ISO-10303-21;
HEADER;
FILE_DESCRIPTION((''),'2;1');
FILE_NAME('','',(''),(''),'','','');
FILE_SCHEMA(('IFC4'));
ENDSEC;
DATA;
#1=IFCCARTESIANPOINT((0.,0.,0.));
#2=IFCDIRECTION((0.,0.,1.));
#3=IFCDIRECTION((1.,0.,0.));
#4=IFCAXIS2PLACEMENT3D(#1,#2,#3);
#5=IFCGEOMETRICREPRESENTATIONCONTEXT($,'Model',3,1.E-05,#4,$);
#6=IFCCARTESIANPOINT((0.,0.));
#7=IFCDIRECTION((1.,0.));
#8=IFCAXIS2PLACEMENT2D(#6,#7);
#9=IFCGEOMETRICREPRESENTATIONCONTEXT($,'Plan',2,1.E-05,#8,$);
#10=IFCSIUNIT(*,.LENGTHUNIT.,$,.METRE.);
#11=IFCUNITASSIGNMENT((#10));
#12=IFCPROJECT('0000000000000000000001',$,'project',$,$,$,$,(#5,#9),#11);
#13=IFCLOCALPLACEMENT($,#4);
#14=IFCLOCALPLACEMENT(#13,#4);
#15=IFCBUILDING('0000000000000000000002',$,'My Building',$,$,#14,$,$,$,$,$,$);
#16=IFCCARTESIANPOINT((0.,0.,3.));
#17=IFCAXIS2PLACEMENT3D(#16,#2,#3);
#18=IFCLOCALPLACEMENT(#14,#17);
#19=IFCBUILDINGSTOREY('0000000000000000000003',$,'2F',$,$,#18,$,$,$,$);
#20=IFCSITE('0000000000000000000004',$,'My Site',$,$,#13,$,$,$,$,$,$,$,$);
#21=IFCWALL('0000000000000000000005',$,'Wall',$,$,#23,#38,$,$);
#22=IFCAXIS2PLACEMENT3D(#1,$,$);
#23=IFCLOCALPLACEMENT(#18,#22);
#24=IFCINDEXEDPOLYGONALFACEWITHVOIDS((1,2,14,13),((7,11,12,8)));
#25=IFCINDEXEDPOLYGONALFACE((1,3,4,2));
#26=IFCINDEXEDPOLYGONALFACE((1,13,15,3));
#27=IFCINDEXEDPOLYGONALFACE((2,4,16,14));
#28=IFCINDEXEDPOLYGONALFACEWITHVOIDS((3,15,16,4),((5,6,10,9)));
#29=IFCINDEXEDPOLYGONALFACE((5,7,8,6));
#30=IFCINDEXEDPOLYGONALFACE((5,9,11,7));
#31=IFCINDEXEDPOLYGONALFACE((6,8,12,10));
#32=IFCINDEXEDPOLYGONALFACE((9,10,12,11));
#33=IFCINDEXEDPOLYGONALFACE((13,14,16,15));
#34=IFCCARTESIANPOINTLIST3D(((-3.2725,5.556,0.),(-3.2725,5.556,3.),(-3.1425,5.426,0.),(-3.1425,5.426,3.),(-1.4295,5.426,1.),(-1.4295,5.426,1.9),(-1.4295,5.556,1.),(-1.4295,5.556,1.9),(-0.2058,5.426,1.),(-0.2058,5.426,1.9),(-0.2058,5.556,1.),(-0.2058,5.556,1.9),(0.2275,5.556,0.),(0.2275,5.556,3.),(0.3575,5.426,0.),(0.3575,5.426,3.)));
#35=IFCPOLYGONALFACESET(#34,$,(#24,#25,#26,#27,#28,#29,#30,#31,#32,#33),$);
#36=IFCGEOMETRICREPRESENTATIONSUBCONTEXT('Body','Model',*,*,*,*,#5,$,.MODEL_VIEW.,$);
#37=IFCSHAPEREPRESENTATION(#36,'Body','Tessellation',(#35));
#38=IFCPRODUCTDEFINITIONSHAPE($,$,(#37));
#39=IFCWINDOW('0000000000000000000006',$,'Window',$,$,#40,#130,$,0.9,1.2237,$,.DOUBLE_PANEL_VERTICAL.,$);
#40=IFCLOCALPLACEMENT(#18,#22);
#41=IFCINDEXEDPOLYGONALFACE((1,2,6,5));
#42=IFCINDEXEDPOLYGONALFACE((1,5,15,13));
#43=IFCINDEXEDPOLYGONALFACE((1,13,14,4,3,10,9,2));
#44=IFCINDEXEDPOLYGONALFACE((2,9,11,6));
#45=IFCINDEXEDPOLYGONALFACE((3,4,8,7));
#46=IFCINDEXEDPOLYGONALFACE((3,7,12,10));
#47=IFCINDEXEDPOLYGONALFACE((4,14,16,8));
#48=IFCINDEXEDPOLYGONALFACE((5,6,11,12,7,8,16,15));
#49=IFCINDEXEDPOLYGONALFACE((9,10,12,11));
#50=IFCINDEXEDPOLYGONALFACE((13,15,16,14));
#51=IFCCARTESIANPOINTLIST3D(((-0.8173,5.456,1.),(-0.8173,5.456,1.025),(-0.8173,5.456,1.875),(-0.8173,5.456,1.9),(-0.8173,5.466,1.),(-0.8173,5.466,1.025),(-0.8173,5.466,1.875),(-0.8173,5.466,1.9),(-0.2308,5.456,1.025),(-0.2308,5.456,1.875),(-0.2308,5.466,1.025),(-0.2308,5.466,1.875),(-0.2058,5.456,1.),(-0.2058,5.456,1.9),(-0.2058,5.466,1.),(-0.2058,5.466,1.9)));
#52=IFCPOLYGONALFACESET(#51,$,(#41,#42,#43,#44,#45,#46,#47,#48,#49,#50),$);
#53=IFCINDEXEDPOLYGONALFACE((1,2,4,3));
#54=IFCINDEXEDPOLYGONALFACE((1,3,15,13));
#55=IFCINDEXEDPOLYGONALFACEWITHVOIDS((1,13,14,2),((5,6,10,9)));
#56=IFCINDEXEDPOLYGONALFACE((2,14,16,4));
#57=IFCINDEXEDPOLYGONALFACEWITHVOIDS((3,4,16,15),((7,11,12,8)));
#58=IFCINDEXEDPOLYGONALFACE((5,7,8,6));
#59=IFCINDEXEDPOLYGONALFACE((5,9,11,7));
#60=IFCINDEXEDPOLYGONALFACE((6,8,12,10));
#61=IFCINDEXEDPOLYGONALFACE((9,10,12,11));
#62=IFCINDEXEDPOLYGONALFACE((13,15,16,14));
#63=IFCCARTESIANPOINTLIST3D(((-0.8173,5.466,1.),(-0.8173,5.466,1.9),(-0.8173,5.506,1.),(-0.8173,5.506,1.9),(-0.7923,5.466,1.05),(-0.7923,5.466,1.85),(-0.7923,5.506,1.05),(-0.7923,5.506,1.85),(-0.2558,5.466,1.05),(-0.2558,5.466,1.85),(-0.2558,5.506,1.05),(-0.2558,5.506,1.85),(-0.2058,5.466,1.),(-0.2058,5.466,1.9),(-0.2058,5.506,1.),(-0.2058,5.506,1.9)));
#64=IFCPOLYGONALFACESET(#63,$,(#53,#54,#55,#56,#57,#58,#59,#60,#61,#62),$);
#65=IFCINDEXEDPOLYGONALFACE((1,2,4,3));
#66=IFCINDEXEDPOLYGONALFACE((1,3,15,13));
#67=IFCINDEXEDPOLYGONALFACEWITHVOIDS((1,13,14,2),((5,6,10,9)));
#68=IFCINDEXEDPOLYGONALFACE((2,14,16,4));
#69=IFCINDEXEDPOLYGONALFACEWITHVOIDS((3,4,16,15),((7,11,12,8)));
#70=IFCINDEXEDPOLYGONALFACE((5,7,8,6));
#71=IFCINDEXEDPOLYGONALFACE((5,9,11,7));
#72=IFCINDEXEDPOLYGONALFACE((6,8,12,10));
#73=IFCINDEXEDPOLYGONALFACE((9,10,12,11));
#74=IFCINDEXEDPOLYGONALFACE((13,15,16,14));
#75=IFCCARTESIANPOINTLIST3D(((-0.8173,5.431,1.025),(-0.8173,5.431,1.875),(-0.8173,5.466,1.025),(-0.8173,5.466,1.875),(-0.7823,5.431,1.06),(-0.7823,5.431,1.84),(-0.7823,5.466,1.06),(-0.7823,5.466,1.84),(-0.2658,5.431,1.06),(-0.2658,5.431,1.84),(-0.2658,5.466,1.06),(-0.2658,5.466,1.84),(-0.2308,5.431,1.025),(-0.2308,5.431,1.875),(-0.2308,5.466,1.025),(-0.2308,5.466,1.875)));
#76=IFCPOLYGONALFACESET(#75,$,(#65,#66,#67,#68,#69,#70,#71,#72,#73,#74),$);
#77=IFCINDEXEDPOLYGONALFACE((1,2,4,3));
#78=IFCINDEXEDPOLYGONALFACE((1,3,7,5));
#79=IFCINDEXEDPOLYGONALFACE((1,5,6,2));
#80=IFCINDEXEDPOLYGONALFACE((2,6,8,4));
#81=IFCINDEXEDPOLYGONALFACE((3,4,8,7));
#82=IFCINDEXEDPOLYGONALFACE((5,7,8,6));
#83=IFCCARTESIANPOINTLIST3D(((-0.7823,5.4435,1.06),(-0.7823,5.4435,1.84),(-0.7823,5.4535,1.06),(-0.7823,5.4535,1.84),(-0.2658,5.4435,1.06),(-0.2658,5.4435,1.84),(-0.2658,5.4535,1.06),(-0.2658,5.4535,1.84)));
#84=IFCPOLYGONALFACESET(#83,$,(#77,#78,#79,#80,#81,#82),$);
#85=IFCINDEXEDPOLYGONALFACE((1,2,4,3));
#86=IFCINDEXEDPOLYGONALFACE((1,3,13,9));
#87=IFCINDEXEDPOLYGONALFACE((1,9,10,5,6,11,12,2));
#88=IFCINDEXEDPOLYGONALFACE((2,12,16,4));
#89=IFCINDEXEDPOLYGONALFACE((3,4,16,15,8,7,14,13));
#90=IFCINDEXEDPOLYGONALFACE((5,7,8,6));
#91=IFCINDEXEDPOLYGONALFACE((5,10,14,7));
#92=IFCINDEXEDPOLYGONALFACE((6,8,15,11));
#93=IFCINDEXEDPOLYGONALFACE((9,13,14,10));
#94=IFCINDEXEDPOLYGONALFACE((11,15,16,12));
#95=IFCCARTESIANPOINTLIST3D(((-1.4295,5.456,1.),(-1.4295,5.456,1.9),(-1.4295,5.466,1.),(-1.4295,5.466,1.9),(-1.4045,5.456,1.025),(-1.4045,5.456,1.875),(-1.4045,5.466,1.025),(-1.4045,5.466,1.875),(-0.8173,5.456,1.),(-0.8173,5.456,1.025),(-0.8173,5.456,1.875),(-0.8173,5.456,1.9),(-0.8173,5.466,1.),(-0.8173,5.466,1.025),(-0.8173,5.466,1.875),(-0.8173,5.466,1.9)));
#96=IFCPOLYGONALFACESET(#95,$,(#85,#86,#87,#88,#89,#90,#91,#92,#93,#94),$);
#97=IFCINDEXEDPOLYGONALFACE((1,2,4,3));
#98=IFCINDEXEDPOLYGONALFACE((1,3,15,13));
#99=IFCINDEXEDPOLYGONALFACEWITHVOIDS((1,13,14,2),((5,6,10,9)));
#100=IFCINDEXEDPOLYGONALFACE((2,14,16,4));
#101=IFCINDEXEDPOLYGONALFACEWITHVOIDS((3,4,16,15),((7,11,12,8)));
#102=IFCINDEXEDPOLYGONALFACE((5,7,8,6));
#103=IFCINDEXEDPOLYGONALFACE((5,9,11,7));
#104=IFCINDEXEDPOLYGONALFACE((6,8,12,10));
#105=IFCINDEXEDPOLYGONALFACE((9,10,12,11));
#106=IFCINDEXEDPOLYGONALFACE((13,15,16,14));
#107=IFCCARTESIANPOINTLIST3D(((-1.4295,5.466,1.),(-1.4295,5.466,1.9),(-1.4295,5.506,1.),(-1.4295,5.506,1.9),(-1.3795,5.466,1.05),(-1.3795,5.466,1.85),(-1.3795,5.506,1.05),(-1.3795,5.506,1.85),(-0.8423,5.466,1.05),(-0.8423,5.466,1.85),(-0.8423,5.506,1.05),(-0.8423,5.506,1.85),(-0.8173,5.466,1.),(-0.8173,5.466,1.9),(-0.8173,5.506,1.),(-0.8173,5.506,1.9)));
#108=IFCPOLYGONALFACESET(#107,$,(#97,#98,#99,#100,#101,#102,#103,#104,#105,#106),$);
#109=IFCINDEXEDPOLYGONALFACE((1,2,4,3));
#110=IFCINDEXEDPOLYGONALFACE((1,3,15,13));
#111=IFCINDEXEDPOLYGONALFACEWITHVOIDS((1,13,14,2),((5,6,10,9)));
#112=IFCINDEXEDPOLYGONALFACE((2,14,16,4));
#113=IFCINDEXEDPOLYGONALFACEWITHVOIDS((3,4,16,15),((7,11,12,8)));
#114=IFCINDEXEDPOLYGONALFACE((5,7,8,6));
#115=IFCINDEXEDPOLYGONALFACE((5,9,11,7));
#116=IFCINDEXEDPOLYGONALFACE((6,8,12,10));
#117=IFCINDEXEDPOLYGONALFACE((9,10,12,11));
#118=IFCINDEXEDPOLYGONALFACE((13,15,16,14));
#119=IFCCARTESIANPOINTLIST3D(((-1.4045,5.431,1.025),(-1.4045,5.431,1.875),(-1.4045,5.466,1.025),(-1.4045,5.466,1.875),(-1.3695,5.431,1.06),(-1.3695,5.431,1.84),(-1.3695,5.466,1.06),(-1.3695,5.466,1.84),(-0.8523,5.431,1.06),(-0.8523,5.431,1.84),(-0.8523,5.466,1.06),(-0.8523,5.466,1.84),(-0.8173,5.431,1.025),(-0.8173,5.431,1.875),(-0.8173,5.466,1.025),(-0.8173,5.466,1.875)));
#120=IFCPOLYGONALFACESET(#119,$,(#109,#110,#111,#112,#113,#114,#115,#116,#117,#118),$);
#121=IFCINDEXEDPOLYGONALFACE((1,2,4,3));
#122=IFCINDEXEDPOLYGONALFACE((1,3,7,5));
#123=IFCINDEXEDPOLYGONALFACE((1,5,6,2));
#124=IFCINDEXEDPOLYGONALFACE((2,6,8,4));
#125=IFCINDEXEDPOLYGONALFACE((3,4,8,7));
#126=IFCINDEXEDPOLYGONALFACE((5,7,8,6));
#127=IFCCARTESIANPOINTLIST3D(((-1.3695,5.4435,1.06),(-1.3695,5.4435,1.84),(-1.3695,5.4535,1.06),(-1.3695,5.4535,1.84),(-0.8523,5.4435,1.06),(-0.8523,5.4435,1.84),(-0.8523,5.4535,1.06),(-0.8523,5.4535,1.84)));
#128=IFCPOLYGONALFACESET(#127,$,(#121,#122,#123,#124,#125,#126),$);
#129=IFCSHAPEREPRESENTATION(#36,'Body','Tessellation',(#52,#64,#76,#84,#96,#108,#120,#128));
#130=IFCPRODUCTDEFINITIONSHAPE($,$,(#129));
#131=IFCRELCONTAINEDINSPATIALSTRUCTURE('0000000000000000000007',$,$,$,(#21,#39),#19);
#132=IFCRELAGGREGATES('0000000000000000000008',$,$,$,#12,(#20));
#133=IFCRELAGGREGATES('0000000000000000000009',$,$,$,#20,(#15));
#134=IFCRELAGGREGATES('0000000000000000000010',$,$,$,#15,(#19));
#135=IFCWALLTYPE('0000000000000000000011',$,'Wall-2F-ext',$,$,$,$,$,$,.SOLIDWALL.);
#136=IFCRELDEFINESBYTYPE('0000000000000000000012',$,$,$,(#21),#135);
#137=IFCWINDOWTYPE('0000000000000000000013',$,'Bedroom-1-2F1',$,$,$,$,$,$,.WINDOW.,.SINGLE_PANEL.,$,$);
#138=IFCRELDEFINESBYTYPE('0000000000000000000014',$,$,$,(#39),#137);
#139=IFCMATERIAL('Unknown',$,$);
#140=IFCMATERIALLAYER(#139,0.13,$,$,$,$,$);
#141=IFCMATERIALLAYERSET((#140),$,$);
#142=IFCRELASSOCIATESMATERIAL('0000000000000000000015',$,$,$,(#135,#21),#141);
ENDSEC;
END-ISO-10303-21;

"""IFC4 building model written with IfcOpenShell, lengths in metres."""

from ifc_helpers import new_model, entity, si_unit, frame, origin_with_axes, origin_2d_with_axis, place, context, subcontext, project, spatial, line, indexed_curve, outline, extrude, shape, source, transform, mapped, material, layer, layer_set, layer_usage, type_object, type_shapes, element, fill, save


model = new_model("IFC4")

# Units and contexts
model_context = context("Model", 3, precision=1e-05, world=origin_with_axes())
plan_context = context("Plan", 2, precision=1e-05, world=origin_2d_with_axis())
body_context_1 = subcontext(model_context, "Body", "Model", "MODEL_VIEW")
body_context_2 = subcontext(plan_context, "Body", "Plan", "PLAN_VIEW")
ifc_project = project(units=[si_unit("LENGTHUNIT", "METRE")], contexts=[model_context, plan_context])

# Site, building, storey
site_placement = place(None, origin_with_axes())
site = spatial("IfcSite", under=ifc_project, at=site_placement, Name="My Site")
building_placement = place(site_placement, origin_with_axes())
building = spatial("IfcBuilding", under=site, at=building_placement, Name="My Building")
storey_placement = place(building_placement, frame((0.0, 0.0, 3.0), z_axis=(0.0, 0.0, 1.0), x_axis=(1.0, 0.0, 0.0)))
storey = spatial("IfcBuildingStorey", under=building, at=storey_placement, Name="2F")

# Shared definitions
ifc_material = material(Name="Unknown")

# Shared definitions
ifc_layer_1 = layer(ifc_material, 0.13)
ifc_layer_set_1 = layer_set([ifc_layer_1])
wall_type_1 = type_object("IfcWallType", Name="Wall-2F-ext", PredefinedType="SOLIDWALL", material=ifc_layer_set_1)

# Wall, opening, window
ifc_layer_usage_1 = layer_usage(ifc_layer_set_1, "AXIS2", "POSITIVE", 0.0)
wall_1_placement = place(storey_placement, frame((0.2275, 5.556, 0.0), z_axis=(0.0, 0.0, 1.0), x_axis=(-1.0, 0.0, 0.0)))
wall_1 = element("IfcWall", 1, at=wall_1_placement, inside=storey, type_object=wall_type_1, material=ifc_layer_usage_1, Name="Wall", context=body_context_1, shape_type="SweptSolid", body=[
    extrude(outline(indexed_curve([(0.0, 0.0), (-0.13, 0.13), (3.37, 0.13), (3.5, 0.0)], segments=[line(1, 2, 3, 4, 1)])), origin_with_axes(), (0.0, 0.0, 1.0), 3.0),
])
shared_shape_1 = source(origin_with_axes(), body_context_1, "Body", "SweptSolid", [
    extrude(outline(indexed_curve([(0.0, 0.0), (1.2237, 0.0), (1.2237, 0.9), (0.0, 0.9)], segments=[line(1, 2, 3, 4, 1)])), frame((0.0, -0.6, 0.0), z_axis=(0.0, -1.0, 0.0), x_axis=(1.0, 0.0, 0.0)), (0.0, 0.0, -1.0), 1.2),
])
opening_1_placement = place(wall_1_placement, frame((0.4333, 0.0, 1.0), z_axis=(0.0, 0.0, 1.0), x_axis=(1.0, 0.0, 0.0)))
opening_1 = element("IfcOpeningElement", 2, at=opening_1_placement, cuts=wall_1, PredefinedType="OPENING", context=body_context_1, shape_type="MappedRepresentation", body=[
    mapped(shared_shape_1, transform((0.0, 0.0, 0.0), x_axis=(1.0, 0.0, 0.0), y_axis=(0.0, 1.0, 0.0), z_axis=(0.0, 0.0, 1.0), scale=1.0)),
])
window_type_1 = type_object("IfcWindowType", Name="Bedroom-1-2F1", PartitioningType="SINGLE_PANEL", PredefinedType="WINDOW")
shared_shape_2 = source(origin_with_axes(), body_context_1, "Body", "SweptSolid", [
    extrude(outline(indexed_curve([(0.6115, 0.0), (0.0, 0.0), (0.0, 0.9), (0.6115, 0.9), (0.6115, 0.875), (0.025, 0.875), (0.025, 0.025), (0.6115, 0.025)], segments=[line(1, 2, 3, 4, 5, 6, 7, 8, 1)])), frame((0.0, 0.09, 0.0), z_axis=(0.0, -1.0, 0.0), x_axis=(1.0, 0.0, 0.0)), (0.0, 0.0, -1.0), 0.01),
    extrude(outline(indexed_curve([(0.0, 0.0), (0.6115, 0.0), (0.6115, 0.9), (0.0, 0.9)], segments=[line(1, 2, 3, 4, 1)]), holes=[indexed_curve([(0.05, 0.05), (0.5865, 0.05), (0.5865, 0.85), (0.05, 0.85)], segments=[line(1, 2, 3, 4, 1)])]), frame((0.0, 0.05, 0.0), z_axis=(0.0, -1.0, 0.0), x_axis=(1.0, 0.0, 0.0)), (0.0, 0.0, -1.0), 0.04),
    extrude(outline(indexed_curve([(0.0, 0.0), (0.5865, 0.0), (0.5865, 0.85), (0.0, 0.85)], segments=[line(1, 2, 3, 4, 1)]), holes=[indexed_curve([(0.035, 0.035), (0.5515, 0.035), (0.5515, 0.815), (0.035, 0.815)], segments=[line(1, 2, 3, 4, 1)])]), frame((0.025, 0.09, 0.025), z_axis=(0.0, -1.0, 0.0), x_axis=(1.0, 0.0, 0.0)), (0.0, 0.0, -1.0), 0.035),
    extrude(outline(indexed_curve([(0.035, 0.035), (0.5515, 0.035), (0.5515, 0.815), (0.035, 0.815)], segments=[line(1, 2, 3, 4, 1)])), frame((0.025, 0.1025, 0.025), z_axis=(0.0, -1.0, 0.0), x_axis=(1.0, 0.0, 0.0)), (0.0, 0.0, -1.0), 0.01),
    extrude(outline(indexed_curve([(0.0, 0.9), (0.6122, 0.9), (0.6122, 0.0), (0.0, 0.0), (0.0, 0.025), (0.5872, 0.025), (0.5872, 0.875), (0.0, 0.875)], segments=[line(1, 2, 3, 4, 5, 6, 7, 8, 1)])), frame((0.6115, 0.09, 0.0), z_axis=(0.0, -1.0, 0.0), x_axis=(1.0, 0.0, 0.0)), (0.0, 0.0, -1.0), 0.01),
    extrude(outline(indexed_curve([(0.0, 0.0), (0.6122, 0.0), (0.6122, 0.9), (0.0, 0.9)], segments=[line(1, 2, 3, 4, 1)]), holes=[indexed_curve([(0.025, 0.05), (0.5622, 0.05), (0.5622, 0.85), (0.025, 0.85)], segments=[line(1, 2, 3, 4, 1)])]), frame((0.6115, 0.05, 0.0), z_axis=(0.0, -1.0, 0.0), x_axis=(1.0, 0.0, 0.0)), (0.0, 0.0, -1.0), 0.04),
    extrude(outline(indexed_curve([(0.0, 0.0), (0.5872, 0.0), (0.5872, 0.85), (0.0, 0.85)], segments=[line(1, 2, 3, 4, 1)]), holes=[indexed_curve([(0.035, 0.035), (0.5522, 0.035), (0.5522, 0.815), (0.035, 0.815)], segments=[line(1, 2, 3, 4, 1)])]), frame((0.6115, 0.09, 0.025), z_axis=(0.0, -1.0, 0.0), x_axis=(1.0, 0.0, 0.0)), (0.0, 0.0, -1.0), 0.035),
    extrude(outline(indexed_curve([(0.035, 0.035), (0.5522, 0.035), (0.5522, 0.815), (0.035, 0.815)], segments=[line(1, 2, 3, 4, 1)])), frame((0.6115, 0.1025, 0.025), z_axis=(0.0, -1.0, 0.0), x_axis=(1.0, 0.0, 0.0)), (0.0, 0.0, -1.0), 0.01),
])
shared_shape_3 = source(origin_with_axes(), body_context_2, "Body", "Curve2D", [
    entity("IfcIndexedPolyCurve", entity("IfcCartesianPointList2D", [[0.05, 0.05], [0.5865, 0.05]])),
    entity("IfcIndexedPolyCurve", entity("IfcCartesianPointList2D", [[0.0, 0.1], [0.025, 0.1], [0.025, 0.09], [0.05, 0.09], [0.05, 0.05], [0.0, 0.05]]), [entity("IfcLineIndex", [1, 2, 3, 4, 5, 6, 1])]),
    entity("IfcIndexedPolyCurve", entity("IfcCartesianPointList2D", [[0.6115, 0.1], [0.6115, 0.1], [0.6115, 0.09], [0.5865, 0.09], [0.5865, 0.05], [0.6115, 0.05]])),
    entity("IfcIndexedPolyCurve", entity("IfcCartesianPointList2D", [[0.025, 0.09], [0.06, 0.09], [0.06, 0.125], [0.025, 0.125]]), [entity("IfcLineIndex", [1, 2, 3, 4, 1])]),
    entity("IfcIndexedPolyCurve", entity("IfcCartesianPointList2D", [[0.6115, 0.09], [0.5765, 0.09], [0.5765, 0.125], [0.6115, 0.125]]), [entity("IfcLineIndex", [1, 2, 3, 4, 1])]),
    entity("IfcIndexedPolyCurve", entity("IfcCartesianPointList2D", [[0.06, 0.09], [0.5765, 0.09]])),
    entity("IfcIndexedPolyCurve", entity("IfcCartesianPointList2D", [[0.06, 0.125], [0.5765, 0.125]])),
    entity("IfcIndexedPolyCurve", entity("IfcCartesianPointList2D", [[0.06, 0.1075], [0.5765, 0.1075]])),
    entity("IfcIndexedPolyCurve", entity("IfcCartesianPointList2D", [[0.6365, 0.05], [1.1737, 0.05]])),
    entity("IfcIndexedPolyCurve", entity("IfcCartesianPointList2D", [[0.6115, 0.1], [0.6115, 0.1], [0.6115, 0.09], [0.6365, 0.09], [0.6365, 0.05], [0.6115, 0.05]])),
    entity("IfcIndexedPolyCurve", entity("IfcCartesianPointList2D", [[1.2237, 0.1], [1.1987, 0.1], [1.1987, 0.09], [1.1737, 0.09], [1.1737, 0.05], [1.2237, 0.05]]), [entity("IfcLineIndex", [1, 2, 3, 4, 5, 6, 1])]),
    entity("IfcIndexedPolyCurve", entity("IfcCartesianPointList2D", [[0.6115, 0.09], [0.6465, 0.09], [0.6465, 0.125], [0.6115, 0.125]]), [entity("IfcLineIndex", [1, 2, 3, 4, 1])]),
    entity("IfcIndexedPolyCurve", entity("IfcCartesianPointList2D", [[1.1987, 0.09], [1.1637, 0.09], [1.1637, 0.125], [1.1987, 0.125]]), [entity("IfcLineIndex", [1, 2, 3, 4, 1])]),
    entity("IfcIndexedPolyCurve", entity("IfcCartesianPointList2D", [[0.6465, 0.09], [1.1637, 0.09]])),
    entity("IfcIndexedPolyCurve", entity("IfcCartesianPointList2D", [[0.6465, 0.125], [1.1637, 0.125]])),
    entity("IfcIndexedPolyCurve", entity("IfcCartesianPointList2D", [[0.6465, 0.1075], [1.1637, 0.1075]])),
])
type_shapes(window_type_1, [shared_shape_2, shared_shape_3])
window_1_placement = place(opening_1_placement, frame((0.0, 0.0, 0.0), z_axis=(0.0, 0.0, 1.0), x_axis=(1.0, 0.0, 0.0)))
window_1 = element("IfcWindow", 3, at=window_1_placement, inside=storey, type_object=window_type_1, Name="Window", OverallHeight=0.9, OverallWidth=1.2237, PartitioningType="DOUBLE_PANEL_VERTICAL", shapes=[
    shape(body_context_1, "Body", "MappedRepresentation", [mapped(shared_shape_2, transform((0.0, 0.0, 0.0), x_axis=(1.0, 0.0, 0.0), y_axis=(0.0, 1.0, 0.0), z_axis=(0.0, 0.0, 1.0), scale=1.0))]),
    shape(body_context_2, "Body", "MappedRepresentation", [mapped(shared_shape_3, transform((0.0, 0.0, 0.0), x_axis=(1.0, 0.0, 0.0), y_axis=(0.0, 1.0, 0.0), z_axis=(0.0, 0.0, 1.0), scale=1.0))]),
])
fill(opening_1, window_1)

save(model, "model.ifc")
